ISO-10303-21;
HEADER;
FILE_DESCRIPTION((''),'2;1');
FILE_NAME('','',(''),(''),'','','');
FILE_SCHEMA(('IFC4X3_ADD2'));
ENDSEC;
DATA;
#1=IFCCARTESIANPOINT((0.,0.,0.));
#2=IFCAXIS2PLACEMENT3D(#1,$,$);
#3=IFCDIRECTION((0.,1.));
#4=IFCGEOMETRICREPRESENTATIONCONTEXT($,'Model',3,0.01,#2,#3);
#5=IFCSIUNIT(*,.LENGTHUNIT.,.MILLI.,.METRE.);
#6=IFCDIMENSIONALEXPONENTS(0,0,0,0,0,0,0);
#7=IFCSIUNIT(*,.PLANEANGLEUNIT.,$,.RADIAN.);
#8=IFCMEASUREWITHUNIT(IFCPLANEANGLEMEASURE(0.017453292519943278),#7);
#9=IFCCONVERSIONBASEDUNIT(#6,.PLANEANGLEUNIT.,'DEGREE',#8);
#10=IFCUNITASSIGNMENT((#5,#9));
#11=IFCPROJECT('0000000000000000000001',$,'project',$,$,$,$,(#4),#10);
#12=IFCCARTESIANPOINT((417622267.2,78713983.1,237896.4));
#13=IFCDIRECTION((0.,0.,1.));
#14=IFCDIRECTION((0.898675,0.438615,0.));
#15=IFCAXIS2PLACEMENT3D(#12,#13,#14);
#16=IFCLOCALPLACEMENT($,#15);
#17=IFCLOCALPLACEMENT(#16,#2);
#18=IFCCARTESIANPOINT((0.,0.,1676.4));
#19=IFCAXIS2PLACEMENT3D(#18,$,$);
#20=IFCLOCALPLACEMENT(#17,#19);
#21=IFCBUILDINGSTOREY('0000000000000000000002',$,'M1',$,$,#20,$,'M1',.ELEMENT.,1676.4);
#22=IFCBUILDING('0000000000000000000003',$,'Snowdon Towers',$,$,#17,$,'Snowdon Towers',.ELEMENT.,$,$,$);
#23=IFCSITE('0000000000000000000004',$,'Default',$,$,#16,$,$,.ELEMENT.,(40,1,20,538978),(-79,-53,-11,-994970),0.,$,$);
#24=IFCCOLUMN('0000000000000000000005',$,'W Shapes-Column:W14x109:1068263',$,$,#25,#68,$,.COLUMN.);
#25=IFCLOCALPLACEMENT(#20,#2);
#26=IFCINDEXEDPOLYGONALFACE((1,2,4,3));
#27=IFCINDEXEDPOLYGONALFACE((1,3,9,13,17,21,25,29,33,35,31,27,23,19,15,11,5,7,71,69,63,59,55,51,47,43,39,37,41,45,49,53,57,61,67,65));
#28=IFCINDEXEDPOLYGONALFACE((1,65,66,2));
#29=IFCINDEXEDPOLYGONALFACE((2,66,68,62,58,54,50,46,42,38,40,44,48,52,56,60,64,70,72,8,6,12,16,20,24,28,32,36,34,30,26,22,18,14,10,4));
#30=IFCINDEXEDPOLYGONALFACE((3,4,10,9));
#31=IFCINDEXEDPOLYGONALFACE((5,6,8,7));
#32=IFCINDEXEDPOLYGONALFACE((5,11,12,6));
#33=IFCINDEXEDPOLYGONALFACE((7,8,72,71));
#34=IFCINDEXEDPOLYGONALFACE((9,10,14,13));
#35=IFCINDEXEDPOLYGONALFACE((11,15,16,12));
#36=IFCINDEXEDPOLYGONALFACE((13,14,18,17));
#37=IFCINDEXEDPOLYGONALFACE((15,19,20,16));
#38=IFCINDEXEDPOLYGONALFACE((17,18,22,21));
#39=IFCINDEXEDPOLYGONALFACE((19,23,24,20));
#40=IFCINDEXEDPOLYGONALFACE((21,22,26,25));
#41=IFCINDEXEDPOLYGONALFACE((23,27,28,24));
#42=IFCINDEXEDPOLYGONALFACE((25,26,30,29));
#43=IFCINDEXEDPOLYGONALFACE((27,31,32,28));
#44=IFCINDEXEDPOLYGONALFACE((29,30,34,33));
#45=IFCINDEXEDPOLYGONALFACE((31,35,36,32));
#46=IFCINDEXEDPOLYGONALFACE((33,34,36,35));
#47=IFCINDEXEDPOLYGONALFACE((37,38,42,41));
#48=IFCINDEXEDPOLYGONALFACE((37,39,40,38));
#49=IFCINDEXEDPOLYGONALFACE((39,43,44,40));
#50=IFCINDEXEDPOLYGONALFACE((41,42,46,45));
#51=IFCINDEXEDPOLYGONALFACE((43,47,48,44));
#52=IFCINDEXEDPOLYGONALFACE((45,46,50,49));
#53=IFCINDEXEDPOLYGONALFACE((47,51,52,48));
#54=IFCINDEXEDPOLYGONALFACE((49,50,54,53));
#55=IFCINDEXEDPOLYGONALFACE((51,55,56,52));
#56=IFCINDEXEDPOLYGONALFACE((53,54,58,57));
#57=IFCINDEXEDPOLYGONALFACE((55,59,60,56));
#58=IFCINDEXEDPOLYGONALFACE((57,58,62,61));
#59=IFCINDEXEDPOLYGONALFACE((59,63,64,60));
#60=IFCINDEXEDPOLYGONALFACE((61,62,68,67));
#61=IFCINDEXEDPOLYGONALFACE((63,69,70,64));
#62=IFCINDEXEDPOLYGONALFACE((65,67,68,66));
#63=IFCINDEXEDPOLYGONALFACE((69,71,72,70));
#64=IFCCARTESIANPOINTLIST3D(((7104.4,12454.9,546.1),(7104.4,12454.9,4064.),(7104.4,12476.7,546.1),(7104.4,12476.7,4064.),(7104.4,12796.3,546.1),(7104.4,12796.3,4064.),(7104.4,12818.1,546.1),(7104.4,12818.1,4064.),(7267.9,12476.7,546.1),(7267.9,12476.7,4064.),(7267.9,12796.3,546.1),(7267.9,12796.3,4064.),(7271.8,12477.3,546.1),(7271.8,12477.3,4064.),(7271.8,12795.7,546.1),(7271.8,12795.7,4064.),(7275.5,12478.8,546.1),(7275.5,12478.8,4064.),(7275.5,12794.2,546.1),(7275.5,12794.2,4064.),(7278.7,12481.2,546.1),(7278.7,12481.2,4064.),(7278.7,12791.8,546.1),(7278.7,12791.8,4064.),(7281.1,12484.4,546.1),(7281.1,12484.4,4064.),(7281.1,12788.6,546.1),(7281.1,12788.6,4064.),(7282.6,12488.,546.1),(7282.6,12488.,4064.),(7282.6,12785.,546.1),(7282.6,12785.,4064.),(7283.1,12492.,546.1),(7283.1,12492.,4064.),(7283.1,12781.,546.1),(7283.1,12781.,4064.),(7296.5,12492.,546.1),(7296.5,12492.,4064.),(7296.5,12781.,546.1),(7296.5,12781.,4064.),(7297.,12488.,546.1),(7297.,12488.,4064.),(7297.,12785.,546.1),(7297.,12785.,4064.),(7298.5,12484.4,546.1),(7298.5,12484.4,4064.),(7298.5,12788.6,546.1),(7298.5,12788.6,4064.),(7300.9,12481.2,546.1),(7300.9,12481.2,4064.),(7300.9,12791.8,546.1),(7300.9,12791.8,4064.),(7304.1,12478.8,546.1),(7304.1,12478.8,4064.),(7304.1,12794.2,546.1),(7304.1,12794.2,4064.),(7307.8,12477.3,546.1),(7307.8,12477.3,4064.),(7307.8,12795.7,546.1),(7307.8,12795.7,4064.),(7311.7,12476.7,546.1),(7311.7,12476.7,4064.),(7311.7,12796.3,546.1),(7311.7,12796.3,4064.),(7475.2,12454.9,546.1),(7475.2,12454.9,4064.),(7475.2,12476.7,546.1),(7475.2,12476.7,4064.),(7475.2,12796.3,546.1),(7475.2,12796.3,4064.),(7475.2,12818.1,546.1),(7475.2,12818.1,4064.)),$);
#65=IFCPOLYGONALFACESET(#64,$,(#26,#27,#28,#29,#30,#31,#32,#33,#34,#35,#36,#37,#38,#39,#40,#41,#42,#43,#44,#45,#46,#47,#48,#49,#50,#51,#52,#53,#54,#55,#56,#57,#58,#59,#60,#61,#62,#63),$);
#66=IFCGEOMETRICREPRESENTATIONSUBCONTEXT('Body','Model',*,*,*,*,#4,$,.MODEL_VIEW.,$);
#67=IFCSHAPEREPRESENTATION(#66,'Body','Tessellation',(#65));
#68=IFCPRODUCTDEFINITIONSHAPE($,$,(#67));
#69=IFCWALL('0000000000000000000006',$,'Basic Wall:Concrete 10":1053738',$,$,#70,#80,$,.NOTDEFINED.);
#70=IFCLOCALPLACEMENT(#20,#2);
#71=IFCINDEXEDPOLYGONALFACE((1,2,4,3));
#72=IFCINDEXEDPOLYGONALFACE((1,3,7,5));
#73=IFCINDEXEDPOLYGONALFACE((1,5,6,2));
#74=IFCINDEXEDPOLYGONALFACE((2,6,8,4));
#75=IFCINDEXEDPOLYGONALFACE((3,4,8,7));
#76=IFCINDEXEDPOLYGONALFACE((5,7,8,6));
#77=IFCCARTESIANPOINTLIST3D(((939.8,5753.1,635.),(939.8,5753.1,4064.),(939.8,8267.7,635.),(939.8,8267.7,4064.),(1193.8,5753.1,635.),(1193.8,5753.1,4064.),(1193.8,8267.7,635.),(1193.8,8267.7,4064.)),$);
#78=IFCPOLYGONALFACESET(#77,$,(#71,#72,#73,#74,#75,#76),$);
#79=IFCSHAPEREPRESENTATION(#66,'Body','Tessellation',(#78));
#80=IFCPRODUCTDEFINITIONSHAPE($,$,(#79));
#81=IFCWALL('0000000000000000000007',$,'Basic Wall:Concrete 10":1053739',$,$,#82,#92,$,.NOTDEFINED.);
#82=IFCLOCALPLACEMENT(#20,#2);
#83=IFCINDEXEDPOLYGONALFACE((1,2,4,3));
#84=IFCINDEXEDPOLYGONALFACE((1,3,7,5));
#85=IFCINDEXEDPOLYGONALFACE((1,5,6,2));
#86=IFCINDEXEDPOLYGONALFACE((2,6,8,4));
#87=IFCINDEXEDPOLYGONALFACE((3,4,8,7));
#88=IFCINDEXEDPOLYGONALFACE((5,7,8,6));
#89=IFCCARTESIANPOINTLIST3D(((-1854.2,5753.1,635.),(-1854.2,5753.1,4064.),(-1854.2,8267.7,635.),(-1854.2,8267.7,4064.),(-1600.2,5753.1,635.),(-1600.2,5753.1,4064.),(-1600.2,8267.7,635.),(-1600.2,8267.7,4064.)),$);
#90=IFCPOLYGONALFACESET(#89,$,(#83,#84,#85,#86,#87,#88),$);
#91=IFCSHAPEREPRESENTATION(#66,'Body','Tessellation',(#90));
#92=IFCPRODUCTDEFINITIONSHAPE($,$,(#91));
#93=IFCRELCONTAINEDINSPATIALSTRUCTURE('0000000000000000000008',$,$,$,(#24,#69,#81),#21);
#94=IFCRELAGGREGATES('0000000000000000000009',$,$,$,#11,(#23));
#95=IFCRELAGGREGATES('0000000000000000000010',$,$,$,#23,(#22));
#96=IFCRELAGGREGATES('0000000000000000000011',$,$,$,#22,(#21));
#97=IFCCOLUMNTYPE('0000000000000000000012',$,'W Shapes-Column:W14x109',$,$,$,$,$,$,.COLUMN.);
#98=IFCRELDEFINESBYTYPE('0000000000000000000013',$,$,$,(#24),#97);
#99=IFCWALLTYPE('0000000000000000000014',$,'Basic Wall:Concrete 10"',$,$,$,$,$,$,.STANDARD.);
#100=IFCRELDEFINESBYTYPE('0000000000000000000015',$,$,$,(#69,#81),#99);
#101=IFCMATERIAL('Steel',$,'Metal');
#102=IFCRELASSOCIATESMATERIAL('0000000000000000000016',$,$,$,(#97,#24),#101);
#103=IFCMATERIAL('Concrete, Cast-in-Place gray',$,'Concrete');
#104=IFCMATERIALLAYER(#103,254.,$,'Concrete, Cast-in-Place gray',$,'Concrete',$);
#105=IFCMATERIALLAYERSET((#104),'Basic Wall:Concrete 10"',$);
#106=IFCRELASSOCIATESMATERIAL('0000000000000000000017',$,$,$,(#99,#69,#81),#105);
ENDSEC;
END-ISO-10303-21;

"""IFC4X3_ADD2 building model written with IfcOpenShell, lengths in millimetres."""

from ifc_helpers import new_model, entity, si_unit, converted_unit, direction, frame, frame_2d, origin, place, context, subcontext, project, spatial, rectangle, i_section, extrude, source, transform, mapped, material, layer, layer_set, material_profile, profile_set, profile_usage, type_object, type_shapes, element, save


model = new_model("IFC4X3_ADD2")

# Units and contexts
model_context = context("Model", 3, precision=0.01, world=origin(), true_north=direction((0.0, 1.0)))
body_context = subcontext(model_context, "Body", "Model", "MODEL_VIEW")
ifc_project = project(units=[si_unit("LENGTHUNIT", "METRE", prefix="MILLI"), converted_unit("PLANEANGLEUNIT", "DEGREE", entity("IfcPlaneAngleMeasure", 0.017453292519943278), si_unit("PLANEANGLEUNIT", "RADIAN"), dimensions=[0, 0, 0, 0, 0, 0, 0])], contexts=[model_context])

# Site, building, storey
site_placement = place(None, frame((417622267.2, 78713983.1, 237896.4), z_axis=(0.0, 0.0, 1.0), x_axis=(0.898675, 0.438615, 0.0)))
site = spatial("IfcSite", under=ifc_project, at=site_placement, Name="Default", CompositionType="ELEMENT", RefLatitude=(40, 1, 20, 538978), RefLongitude=(-79, -53, -11, -994970), RefElevation=0.0)
building_placement = place(site_placement, origin())
building = spatial("IfcBuilding", under=site, at=building_placement, Name="Snowdon Towers", LongName="Snowdon Towers", CompositionType="ELEMENT")
storey_placement = place(building_placement, frame((0.0, 0.0, 1676.4)))
storey = spatial("IfcBuildingStorey", under=building, at=storey_placement, Name="M1", LongName="M1", CompositionType="ELEMENT", Elevation=1676.4)

# Column
ifc_material_1 = material(Name="Steel", Category="Metal")
ifc_material_profile_1 = material_profile(ifc_material_1, i_section(OverallWidth=370.8, OverallDepth=363.2, WebThickness=13.3, FlangeThickness=21.8, FilletRadius=15.2, at=frame_2d((0.0, 0.0), x_axis=(1.0, 0.0))), Name="W14x109")
ifc_profile_set_1 = profile_set([ifc_material_profile_1], Name="W14x109")
ifc_profile_usage_1 = profile_usage(ifc_profile_set_1)
column_type_1 = type_object("IfcColumnType", Name="W Shapes-Column:W14x109", PredefinedType="COLUMN", material=ifc_profile_set_1)
shared_shape_1 = source(origin(), body_context, "Body", "SweptSolid", [
    extrude(i_section(OverallWidth=370.8, OverallDepth=363.2, WebThickness=13.3, FlangeThickness=21.8, FilletRadius=15.2, at=frame_2d((0.0, 0.0), x_axis=(1.0, 0.0))), frame((0.0, 0.0, 2222.5), z_axis=(0.0, 0.0, 1.0), x_axis=(-1.0, 0.0, 0.0)), (0.0, 0.0, 1.0), 3517.9),
])
type_shapes(column_type_1, [shared_shape_1])
column_placement = place(storey_placement, frame((7289.8, 12636.5, -1676.4)))
element("IfcColumn", 1, at=column_placement, inside=storey, type_object=column_type_1, material=ifc_profile_usage_1, Name="W Shapes-Column:W14x109:1068263", PredefinedType="COLUMN", context=body_context, shape_type="MappedRepresentation", body=[
    mapped(shared_shape_1, transform((0.0, 0.0, 0.0), scale=1.0)),
])

# Shared definitions
ifc_material_2 = material(Name="Concrete, Cast-in-Place gray", Category="Concrete")

# Walls
ifc_layer_1 = layer(ifc_material_2, 254.0, Name="Concrete, Cast-in-Place gray", Category="Concrete")
ifc_layer_set_1 = layer_set([ifc_layer_1], Name="Basic Wall:Concrete 10\"")
wall_type = type_object("IfcWallType", Name="Basic Wall:Concrete 10\"", PredefinedType="STANDARD", material=ifc_layer_set_1)
wall_1_placement = place(storey_placement, frame((1066.8, 8267.7, 635.0), z_axis=(0.0, 0.0, 1.0), x_axis=(0.0, -1.0, 0.0)))
element("IfcWall", 2, at=wall_1_placement, inside=storey, type_object=wall_type, material=ifc_layer_set_1, Name="Basic Wall:Concrete 10\":1053738", PredefinedType="NOTDEFINED", context=body_context, shape_type="SweptSolid", body=[
    extrude(rectangle(XDim=2514.6, YDim=254.0, at=frame_2d((1257.3, 0.0), x_axis=(-1.0, 0.0))), origin(), (0.0, 0.0, 1.0), 3429.0),
])
wall_2_placement = place(storey_placement, frame((-1727.2, 5753.1, 635.0), z_axis=(0.0, 0.0, 1.0), x_axis=(0.0, 1.0, 0.0)))
element("IfcWall", 3, at=wall_2_placement, inside=storey, type_object=wall_type, material=ifc_layer_set_1, Name="Basic Wall:Concrete 10\":1053739", PredefinedType="NOTDEFINED", context=body_context, shape_type="SweptSolid", body=[
    extrude(rectangle(XDim=2514.6, YDim=254.0, at=frame_2d((1257.3, 0.0), x_axis=(-1.0, 0.0))), origin(), (0.0, 0.0, 1.0), 3429.0),
])

save(model, "model.ifc")
